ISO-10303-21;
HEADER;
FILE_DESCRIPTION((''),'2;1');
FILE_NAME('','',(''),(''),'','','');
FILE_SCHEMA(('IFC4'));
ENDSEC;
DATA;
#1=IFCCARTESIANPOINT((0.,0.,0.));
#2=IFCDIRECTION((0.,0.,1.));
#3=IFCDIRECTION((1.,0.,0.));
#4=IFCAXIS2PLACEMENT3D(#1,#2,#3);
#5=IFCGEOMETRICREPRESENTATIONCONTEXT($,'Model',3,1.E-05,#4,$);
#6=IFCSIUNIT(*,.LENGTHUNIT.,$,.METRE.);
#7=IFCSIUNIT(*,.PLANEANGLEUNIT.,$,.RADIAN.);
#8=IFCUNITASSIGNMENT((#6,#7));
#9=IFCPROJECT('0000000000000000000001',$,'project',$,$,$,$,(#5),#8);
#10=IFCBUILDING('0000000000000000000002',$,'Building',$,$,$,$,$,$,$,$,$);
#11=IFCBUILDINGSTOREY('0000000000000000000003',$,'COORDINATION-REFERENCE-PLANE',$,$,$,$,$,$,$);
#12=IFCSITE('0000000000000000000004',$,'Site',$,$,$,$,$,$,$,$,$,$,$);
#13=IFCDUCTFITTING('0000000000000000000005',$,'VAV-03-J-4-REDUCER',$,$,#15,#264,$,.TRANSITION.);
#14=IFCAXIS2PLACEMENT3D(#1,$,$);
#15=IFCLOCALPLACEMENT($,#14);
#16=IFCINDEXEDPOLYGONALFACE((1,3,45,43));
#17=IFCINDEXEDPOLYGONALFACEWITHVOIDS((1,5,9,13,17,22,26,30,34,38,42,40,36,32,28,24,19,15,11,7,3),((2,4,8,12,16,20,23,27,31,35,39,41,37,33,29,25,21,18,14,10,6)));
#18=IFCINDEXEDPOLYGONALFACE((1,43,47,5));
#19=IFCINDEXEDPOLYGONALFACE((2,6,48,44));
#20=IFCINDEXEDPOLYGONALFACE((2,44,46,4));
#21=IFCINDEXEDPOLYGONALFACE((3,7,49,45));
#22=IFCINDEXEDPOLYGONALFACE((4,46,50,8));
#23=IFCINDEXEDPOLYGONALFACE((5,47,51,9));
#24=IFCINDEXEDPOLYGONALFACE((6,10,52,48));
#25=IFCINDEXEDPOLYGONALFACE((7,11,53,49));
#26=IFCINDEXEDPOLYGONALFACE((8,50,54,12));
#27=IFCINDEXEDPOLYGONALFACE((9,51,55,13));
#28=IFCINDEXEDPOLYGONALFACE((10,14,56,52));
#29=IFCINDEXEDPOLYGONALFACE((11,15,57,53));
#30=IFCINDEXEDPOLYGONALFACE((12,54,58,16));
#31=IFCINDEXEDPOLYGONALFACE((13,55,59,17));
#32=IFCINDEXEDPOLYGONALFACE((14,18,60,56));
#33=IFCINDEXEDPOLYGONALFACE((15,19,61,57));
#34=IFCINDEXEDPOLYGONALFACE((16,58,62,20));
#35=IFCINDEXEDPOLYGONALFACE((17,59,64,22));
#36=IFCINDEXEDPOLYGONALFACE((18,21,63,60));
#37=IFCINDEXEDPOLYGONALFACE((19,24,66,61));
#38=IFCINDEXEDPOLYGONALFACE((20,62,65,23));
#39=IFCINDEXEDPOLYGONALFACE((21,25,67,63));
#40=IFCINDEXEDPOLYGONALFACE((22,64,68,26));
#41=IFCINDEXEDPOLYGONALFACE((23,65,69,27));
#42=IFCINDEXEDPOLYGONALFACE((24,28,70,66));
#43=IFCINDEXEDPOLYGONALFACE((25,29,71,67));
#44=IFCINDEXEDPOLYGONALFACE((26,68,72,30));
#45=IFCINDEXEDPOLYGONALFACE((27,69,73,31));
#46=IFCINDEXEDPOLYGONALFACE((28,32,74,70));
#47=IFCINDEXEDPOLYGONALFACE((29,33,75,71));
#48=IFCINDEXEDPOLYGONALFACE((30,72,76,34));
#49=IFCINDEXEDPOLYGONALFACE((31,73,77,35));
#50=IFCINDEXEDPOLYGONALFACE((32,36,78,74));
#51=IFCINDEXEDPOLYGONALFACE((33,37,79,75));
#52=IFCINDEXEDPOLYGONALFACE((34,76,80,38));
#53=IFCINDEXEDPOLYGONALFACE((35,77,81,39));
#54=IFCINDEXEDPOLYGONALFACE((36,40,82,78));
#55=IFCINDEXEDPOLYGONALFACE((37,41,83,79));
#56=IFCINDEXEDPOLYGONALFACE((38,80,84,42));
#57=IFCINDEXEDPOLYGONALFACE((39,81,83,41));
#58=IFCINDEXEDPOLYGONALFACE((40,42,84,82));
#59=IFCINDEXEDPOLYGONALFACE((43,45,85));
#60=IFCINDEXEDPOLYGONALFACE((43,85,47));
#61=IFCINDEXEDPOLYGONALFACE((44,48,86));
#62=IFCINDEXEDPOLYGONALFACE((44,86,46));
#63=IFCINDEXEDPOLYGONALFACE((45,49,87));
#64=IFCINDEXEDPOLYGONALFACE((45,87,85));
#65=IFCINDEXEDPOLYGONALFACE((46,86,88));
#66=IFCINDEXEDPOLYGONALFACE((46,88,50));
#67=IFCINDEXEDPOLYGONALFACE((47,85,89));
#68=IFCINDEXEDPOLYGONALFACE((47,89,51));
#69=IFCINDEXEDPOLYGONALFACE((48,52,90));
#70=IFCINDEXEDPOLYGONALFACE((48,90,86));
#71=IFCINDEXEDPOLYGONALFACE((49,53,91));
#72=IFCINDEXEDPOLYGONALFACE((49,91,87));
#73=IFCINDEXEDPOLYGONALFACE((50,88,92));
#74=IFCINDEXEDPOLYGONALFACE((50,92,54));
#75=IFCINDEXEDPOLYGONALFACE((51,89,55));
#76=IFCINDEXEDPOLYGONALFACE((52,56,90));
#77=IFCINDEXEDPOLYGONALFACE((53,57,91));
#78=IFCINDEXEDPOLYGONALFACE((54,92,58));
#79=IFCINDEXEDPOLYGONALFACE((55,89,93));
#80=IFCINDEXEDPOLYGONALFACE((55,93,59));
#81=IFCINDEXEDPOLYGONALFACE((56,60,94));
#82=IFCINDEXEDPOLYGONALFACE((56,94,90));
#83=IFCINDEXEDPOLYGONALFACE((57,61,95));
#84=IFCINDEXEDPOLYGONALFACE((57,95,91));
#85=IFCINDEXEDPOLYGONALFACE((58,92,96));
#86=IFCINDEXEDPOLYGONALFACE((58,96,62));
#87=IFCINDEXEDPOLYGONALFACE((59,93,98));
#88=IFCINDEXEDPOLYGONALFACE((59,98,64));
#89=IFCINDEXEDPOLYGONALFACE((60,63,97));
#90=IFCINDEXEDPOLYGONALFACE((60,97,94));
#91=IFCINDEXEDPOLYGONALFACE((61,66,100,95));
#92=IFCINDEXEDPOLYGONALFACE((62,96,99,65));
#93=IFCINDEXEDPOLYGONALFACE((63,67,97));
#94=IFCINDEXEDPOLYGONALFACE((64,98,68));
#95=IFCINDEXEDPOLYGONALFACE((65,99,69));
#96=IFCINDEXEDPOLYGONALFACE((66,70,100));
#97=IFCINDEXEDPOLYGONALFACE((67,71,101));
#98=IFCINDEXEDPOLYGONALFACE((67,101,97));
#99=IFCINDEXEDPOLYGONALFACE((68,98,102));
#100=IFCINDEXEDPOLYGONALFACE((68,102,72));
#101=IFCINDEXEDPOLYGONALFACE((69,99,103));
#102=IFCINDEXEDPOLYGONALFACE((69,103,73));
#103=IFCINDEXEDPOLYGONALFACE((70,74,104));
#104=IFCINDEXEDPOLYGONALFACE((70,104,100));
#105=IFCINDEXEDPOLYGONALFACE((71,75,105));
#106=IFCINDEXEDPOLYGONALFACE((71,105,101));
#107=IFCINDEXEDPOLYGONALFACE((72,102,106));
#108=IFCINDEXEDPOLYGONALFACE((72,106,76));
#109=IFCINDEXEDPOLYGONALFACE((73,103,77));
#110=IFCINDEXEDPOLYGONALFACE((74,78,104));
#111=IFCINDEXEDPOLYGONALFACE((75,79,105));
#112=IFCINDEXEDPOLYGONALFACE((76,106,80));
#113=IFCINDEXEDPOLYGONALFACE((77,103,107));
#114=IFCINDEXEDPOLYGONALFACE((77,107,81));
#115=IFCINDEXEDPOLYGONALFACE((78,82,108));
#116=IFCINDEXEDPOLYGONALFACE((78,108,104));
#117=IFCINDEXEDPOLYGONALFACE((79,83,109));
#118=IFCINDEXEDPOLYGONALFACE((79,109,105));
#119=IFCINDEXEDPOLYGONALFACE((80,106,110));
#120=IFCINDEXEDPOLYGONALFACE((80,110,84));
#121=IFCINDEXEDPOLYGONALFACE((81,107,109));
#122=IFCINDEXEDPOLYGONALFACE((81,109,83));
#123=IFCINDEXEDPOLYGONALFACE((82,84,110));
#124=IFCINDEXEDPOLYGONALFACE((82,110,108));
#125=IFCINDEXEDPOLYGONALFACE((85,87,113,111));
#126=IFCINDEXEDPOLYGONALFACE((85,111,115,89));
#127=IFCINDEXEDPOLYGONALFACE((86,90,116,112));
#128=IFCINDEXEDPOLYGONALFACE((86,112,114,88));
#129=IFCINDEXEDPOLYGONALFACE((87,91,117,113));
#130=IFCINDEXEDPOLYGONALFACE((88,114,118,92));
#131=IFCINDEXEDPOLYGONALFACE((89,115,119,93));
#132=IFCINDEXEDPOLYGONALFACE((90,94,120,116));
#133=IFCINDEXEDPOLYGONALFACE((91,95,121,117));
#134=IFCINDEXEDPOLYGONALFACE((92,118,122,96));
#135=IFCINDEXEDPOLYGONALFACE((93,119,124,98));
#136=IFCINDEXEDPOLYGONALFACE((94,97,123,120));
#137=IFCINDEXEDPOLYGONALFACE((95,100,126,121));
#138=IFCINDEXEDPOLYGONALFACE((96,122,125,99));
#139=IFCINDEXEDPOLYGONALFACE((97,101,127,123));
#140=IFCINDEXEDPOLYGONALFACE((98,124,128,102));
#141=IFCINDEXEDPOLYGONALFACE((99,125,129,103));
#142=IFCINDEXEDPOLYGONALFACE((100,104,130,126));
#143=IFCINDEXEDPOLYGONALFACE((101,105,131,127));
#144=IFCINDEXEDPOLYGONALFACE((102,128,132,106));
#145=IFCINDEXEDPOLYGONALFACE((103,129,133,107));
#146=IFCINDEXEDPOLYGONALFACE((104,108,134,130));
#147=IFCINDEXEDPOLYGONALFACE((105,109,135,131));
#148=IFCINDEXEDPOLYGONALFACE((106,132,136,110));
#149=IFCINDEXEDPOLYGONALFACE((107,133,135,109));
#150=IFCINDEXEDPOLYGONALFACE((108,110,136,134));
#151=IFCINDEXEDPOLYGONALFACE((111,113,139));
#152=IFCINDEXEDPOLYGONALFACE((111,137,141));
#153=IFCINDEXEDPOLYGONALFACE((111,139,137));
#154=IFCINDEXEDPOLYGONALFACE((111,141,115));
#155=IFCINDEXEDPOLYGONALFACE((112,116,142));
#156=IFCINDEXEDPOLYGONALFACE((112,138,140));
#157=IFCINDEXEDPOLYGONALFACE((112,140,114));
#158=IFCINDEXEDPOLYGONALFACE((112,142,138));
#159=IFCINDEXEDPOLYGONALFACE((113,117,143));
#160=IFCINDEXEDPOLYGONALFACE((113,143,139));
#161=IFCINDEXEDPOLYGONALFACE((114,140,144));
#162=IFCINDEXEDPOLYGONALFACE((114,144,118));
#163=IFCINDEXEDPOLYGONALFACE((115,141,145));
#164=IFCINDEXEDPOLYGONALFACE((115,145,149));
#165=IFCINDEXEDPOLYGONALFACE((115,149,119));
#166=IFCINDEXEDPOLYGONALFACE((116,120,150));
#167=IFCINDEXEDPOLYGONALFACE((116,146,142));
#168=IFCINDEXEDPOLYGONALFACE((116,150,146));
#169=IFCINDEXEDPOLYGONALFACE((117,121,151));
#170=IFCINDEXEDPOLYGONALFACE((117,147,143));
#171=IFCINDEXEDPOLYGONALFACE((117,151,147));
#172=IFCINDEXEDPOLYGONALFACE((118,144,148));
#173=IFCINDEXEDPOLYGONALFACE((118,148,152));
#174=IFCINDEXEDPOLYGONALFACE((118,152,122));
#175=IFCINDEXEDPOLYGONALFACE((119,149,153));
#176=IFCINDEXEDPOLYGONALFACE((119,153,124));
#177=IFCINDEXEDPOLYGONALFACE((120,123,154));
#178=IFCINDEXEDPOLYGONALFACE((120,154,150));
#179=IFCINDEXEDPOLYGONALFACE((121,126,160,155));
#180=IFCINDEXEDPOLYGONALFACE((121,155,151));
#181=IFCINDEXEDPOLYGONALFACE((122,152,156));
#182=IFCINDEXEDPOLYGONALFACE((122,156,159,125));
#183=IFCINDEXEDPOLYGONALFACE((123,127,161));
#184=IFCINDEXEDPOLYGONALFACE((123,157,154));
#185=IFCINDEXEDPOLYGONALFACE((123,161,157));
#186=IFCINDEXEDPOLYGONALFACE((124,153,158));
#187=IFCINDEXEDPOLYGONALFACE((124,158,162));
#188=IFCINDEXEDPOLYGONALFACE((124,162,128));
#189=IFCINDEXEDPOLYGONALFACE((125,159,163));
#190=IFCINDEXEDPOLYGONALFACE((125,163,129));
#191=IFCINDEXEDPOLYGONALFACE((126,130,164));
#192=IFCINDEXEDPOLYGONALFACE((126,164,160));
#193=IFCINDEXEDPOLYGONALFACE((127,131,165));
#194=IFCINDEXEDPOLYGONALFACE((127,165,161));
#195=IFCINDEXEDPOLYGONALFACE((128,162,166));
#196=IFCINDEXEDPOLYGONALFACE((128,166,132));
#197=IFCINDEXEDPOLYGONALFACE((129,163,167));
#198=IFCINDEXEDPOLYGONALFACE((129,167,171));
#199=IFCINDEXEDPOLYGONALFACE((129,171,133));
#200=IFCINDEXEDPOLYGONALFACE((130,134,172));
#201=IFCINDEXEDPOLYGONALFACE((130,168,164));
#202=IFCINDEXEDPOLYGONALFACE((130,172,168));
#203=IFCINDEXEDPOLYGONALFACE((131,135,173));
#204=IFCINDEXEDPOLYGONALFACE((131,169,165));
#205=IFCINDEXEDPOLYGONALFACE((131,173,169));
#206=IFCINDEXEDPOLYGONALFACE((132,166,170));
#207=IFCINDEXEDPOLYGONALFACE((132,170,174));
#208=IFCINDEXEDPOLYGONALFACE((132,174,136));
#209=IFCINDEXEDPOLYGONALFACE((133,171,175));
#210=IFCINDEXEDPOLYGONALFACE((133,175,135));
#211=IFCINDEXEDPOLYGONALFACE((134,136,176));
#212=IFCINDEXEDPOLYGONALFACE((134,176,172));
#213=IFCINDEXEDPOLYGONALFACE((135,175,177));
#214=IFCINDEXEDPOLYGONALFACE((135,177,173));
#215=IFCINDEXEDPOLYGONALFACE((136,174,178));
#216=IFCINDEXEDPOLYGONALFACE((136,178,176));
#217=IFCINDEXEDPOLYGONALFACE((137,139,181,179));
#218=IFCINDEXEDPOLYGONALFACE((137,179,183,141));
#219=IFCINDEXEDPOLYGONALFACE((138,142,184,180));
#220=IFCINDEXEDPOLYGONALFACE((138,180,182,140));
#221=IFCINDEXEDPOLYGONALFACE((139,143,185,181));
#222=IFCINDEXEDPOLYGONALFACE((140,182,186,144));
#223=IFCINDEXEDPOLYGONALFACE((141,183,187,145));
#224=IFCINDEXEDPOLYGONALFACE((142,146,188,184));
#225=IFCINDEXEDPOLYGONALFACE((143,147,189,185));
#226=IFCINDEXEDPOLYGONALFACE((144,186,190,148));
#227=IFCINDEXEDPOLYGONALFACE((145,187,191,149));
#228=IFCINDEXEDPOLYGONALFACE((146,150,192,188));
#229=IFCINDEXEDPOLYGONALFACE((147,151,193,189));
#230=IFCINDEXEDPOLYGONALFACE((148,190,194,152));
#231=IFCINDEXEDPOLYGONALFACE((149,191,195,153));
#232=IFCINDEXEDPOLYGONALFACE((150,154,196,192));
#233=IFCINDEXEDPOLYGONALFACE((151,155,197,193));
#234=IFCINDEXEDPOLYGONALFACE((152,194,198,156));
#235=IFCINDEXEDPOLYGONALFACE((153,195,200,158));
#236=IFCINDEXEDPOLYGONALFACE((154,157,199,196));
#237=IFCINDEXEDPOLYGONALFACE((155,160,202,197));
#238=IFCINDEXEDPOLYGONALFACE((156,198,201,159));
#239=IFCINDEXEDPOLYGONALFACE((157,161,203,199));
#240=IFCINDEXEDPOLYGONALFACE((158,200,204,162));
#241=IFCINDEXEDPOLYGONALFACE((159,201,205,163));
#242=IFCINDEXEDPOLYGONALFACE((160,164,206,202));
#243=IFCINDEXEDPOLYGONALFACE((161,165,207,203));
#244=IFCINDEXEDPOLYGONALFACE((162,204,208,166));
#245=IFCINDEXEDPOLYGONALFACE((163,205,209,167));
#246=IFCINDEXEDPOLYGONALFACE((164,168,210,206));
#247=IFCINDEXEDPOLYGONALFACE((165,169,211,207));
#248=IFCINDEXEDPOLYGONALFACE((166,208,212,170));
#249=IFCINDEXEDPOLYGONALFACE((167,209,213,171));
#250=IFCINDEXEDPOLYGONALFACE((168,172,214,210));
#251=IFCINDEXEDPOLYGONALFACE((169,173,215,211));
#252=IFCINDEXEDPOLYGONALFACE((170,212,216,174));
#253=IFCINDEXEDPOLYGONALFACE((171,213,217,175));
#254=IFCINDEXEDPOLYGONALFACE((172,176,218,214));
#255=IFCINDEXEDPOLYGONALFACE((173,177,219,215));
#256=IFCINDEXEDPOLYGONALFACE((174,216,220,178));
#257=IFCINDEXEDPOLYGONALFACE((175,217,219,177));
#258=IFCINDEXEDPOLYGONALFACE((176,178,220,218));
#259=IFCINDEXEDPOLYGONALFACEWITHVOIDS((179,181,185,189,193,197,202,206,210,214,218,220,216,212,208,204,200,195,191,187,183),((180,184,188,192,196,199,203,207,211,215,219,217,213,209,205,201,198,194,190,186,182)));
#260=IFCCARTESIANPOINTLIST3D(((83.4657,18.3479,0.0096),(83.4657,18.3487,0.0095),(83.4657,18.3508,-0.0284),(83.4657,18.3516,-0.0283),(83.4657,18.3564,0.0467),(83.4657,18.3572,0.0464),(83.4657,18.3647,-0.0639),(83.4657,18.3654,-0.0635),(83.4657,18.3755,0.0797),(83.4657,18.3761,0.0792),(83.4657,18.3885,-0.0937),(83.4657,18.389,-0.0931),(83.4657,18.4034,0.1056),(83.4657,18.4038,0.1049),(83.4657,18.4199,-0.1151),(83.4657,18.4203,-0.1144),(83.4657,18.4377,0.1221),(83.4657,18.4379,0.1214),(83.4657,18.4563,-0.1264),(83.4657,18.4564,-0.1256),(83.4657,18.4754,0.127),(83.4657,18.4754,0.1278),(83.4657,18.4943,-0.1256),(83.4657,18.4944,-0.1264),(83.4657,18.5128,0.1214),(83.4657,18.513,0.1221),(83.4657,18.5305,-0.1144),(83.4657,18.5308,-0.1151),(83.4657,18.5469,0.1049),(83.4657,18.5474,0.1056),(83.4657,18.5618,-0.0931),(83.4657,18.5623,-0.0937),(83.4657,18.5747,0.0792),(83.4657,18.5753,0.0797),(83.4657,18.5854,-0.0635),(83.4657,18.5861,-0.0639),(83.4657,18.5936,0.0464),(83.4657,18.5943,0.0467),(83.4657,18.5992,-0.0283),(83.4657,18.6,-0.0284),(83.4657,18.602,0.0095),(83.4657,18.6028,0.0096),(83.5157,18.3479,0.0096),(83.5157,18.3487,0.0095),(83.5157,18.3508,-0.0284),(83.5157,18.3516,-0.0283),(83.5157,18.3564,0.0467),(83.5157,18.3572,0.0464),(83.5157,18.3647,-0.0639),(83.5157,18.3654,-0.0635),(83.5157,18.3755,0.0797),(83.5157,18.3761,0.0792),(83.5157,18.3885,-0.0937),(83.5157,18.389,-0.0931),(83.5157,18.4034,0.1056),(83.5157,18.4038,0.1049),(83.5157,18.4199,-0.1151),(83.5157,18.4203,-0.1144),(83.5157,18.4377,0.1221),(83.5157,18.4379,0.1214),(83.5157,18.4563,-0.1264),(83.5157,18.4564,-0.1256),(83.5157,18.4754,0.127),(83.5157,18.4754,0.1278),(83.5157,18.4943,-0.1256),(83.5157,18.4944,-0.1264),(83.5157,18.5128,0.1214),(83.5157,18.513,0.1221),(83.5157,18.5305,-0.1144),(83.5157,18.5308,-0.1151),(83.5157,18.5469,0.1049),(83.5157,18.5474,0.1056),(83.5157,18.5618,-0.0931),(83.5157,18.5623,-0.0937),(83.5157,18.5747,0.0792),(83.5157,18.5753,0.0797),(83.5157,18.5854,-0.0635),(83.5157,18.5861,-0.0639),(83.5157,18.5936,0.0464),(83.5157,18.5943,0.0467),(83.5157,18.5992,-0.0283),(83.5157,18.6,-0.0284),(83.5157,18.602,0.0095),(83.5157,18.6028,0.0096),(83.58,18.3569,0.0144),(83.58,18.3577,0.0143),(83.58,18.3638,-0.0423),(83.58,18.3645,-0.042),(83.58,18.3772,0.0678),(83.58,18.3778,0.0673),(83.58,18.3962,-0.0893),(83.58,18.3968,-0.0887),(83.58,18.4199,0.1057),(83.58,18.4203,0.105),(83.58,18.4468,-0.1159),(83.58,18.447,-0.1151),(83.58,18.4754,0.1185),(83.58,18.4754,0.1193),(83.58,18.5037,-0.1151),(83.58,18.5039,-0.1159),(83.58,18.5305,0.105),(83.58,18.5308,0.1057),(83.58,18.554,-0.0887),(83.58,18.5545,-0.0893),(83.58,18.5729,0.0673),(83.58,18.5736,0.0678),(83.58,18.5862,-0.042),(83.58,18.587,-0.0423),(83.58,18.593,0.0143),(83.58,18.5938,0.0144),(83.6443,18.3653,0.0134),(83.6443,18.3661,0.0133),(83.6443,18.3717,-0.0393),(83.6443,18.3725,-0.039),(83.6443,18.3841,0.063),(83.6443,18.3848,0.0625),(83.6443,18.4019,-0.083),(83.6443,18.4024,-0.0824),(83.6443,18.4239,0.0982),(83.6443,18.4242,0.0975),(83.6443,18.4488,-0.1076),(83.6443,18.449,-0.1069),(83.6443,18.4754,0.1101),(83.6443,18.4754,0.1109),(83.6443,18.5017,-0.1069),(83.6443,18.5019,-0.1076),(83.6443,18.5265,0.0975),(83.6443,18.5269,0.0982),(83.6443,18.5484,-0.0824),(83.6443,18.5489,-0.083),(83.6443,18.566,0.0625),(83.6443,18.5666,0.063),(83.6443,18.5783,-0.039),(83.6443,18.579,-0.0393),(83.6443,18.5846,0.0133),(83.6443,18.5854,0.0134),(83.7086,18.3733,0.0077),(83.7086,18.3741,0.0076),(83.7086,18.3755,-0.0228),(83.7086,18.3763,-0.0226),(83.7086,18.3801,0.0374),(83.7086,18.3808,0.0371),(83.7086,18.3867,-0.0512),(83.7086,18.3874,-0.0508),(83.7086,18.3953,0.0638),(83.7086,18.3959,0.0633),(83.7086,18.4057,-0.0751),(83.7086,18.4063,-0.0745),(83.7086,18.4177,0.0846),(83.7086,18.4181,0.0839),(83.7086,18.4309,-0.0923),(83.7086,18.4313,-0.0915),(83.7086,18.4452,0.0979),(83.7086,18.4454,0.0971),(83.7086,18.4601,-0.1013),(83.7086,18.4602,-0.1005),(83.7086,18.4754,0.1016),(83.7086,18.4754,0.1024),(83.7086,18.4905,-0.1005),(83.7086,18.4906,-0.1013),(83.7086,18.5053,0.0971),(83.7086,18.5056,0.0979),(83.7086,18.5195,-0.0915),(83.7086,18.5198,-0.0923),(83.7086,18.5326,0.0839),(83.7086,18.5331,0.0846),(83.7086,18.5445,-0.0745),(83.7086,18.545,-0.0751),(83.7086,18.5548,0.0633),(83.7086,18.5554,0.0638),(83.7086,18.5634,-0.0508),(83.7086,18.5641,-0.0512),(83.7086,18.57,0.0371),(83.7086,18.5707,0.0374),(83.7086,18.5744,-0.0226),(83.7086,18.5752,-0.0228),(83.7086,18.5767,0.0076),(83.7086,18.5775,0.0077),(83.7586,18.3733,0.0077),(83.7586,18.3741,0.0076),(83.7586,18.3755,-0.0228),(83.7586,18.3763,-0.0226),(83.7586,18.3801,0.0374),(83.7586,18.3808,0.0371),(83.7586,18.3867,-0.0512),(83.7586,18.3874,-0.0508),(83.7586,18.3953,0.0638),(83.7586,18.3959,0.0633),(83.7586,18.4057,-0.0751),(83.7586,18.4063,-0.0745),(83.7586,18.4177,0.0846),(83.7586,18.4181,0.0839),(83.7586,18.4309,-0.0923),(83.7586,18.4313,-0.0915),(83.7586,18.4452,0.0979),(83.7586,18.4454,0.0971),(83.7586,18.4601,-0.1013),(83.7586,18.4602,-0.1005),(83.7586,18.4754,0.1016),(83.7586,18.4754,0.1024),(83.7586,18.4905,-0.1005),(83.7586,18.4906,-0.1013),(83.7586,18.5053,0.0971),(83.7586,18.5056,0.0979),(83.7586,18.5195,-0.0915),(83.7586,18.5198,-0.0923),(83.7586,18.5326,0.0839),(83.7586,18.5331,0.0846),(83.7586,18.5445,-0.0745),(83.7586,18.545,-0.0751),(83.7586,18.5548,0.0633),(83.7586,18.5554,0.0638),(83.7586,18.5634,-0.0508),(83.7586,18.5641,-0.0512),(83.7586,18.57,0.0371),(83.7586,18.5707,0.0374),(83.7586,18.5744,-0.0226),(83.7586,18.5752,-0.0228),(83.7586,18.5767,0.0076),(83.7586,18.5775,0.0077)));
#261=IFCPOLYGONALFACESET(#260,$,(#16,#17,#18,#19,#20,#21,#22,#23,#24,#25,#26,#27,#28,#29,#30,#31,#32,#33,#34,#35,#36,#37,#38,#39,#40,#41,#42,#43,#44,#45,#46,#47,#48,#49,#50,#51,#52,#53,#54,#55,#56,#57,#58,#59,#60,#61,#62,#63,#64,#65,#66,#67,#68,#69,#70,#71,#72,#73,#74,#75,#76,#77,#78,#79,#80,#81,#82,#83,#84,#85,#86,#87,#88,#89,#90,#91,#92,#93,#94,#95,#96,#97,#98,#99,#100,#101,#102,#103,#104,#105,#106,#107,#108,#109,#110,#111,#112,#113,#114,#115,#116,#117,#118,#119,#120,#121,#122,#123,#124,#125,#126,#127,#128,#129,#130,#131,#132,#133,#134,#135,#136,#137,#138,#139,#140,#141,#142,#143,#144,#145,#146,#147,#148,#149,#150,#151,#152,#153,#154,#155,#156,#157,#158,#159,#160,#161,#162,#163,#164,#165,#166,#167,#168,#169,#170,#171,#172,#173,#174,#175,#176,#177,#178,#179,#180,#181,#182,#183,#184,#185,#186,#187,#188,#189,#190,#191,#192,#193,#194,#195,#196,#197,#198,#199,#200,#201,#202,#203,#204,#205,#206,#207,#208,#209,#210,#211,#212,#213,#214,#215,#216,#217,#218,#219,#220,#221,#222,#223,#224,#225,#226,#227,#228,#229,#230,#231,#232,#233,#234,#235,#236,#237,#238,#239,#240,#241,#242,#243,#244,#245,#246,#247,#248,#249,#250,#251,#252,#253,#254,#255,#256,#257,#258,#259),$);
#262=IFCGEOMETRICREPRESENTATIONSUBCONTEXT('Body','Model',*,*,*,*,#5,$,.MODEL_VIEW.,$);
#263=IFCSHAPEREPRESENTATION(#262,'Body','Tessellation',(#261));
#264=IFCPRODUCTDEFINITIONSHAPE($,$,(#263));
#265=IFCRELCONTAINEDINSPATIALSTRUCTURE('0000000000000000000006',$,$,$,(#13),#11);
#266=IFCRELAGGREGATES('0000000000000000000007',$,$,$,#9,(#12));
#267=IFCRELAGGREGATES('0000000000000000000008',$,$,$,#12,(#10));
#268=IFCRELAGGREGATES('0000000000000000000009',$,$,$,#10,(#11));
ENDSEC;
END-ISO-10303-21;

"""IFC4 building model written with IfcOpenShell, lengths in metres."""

from ifc_helpers import new_model, entity, si_unit, frame, origin_with_axes, place, context, subcontext, project, spatial, element, save


model = new_model("IFC4")

# Units and contexts
model_context = context("Model", 3, precision=1e-05, world=origin_with_axes())
body_context_1 = subcontext(model_context, "Body", "Model", "MODEL_VIEW")
ifc_project = project(units=[si_unit("LENGTHUNIT", "METRE"), si_unit("PLANEANGLEUNIT", "RADIAN")], contexts=[model_context])

# Site, building, storey
site = spatial("IfcSite", under=ifc_project, Name="Site")
building = spatial("IfcBuilding", under=site, Name="Building")
storey = spatial("IfcBuildingStorey", under=building, Name="COORDINATION-REFERENCE-PLANE")

# Duct fitting
for number, where, z_axis, x_axis, name in (
    (1, (83.4657, 18.4754, 0.0), (0.0, 1.0, 0.0), (0.0, 0.0, 1.0), "VAV-03-J-4-REDUCER"),
):
    element("IfcDuctFitting", number, at=place(None, frame(where, z_axis=z_axis, x_axis=x_axis)), inside=storey, Name=name, PredefinedType="TRANSITION", context=body_context_1, shape_type="SweptSolid", body=[
        entity("IfcRevolvedAreaSolid", entity("IfcArbitraryClosedProfileDef", "AREA", None, entity("IfcPolyline", [entity("IfcCartesianPoint", [0.1278, 0.0]), entity("IfcCartesianPoint", [0.1278, 0.05]), entity("IfcCartesianPoint", [0.1024, 0.2429]), entity("IfcCartesianPoint", [0.1024, 0.2929]), entity("IfcCartesianPoint", [0.1016, 0.2929]), entity("IfcCartesianPoint", [0.1016, 0.2429]), entity("IfcCartesianPoint", [0.127, 0.05]), entity("IfcCartesianPoint", [0.127, 0.0]), entity("IfcCartesianPoint", [0.1278, 0.0])])), entity("IfcAxis2Placement3D", entity("IfcCartesianPoint", [0.0, 0.0, 0.0])), entity("IfcAxis1Placement", entity("IfcCartesianPoint", [0.0, 0.0, 0.0]), entity("IfcDirection", [0.0, 1.0, 0.0])), 6.283185),
    ])

save(model, "model.ifc")
